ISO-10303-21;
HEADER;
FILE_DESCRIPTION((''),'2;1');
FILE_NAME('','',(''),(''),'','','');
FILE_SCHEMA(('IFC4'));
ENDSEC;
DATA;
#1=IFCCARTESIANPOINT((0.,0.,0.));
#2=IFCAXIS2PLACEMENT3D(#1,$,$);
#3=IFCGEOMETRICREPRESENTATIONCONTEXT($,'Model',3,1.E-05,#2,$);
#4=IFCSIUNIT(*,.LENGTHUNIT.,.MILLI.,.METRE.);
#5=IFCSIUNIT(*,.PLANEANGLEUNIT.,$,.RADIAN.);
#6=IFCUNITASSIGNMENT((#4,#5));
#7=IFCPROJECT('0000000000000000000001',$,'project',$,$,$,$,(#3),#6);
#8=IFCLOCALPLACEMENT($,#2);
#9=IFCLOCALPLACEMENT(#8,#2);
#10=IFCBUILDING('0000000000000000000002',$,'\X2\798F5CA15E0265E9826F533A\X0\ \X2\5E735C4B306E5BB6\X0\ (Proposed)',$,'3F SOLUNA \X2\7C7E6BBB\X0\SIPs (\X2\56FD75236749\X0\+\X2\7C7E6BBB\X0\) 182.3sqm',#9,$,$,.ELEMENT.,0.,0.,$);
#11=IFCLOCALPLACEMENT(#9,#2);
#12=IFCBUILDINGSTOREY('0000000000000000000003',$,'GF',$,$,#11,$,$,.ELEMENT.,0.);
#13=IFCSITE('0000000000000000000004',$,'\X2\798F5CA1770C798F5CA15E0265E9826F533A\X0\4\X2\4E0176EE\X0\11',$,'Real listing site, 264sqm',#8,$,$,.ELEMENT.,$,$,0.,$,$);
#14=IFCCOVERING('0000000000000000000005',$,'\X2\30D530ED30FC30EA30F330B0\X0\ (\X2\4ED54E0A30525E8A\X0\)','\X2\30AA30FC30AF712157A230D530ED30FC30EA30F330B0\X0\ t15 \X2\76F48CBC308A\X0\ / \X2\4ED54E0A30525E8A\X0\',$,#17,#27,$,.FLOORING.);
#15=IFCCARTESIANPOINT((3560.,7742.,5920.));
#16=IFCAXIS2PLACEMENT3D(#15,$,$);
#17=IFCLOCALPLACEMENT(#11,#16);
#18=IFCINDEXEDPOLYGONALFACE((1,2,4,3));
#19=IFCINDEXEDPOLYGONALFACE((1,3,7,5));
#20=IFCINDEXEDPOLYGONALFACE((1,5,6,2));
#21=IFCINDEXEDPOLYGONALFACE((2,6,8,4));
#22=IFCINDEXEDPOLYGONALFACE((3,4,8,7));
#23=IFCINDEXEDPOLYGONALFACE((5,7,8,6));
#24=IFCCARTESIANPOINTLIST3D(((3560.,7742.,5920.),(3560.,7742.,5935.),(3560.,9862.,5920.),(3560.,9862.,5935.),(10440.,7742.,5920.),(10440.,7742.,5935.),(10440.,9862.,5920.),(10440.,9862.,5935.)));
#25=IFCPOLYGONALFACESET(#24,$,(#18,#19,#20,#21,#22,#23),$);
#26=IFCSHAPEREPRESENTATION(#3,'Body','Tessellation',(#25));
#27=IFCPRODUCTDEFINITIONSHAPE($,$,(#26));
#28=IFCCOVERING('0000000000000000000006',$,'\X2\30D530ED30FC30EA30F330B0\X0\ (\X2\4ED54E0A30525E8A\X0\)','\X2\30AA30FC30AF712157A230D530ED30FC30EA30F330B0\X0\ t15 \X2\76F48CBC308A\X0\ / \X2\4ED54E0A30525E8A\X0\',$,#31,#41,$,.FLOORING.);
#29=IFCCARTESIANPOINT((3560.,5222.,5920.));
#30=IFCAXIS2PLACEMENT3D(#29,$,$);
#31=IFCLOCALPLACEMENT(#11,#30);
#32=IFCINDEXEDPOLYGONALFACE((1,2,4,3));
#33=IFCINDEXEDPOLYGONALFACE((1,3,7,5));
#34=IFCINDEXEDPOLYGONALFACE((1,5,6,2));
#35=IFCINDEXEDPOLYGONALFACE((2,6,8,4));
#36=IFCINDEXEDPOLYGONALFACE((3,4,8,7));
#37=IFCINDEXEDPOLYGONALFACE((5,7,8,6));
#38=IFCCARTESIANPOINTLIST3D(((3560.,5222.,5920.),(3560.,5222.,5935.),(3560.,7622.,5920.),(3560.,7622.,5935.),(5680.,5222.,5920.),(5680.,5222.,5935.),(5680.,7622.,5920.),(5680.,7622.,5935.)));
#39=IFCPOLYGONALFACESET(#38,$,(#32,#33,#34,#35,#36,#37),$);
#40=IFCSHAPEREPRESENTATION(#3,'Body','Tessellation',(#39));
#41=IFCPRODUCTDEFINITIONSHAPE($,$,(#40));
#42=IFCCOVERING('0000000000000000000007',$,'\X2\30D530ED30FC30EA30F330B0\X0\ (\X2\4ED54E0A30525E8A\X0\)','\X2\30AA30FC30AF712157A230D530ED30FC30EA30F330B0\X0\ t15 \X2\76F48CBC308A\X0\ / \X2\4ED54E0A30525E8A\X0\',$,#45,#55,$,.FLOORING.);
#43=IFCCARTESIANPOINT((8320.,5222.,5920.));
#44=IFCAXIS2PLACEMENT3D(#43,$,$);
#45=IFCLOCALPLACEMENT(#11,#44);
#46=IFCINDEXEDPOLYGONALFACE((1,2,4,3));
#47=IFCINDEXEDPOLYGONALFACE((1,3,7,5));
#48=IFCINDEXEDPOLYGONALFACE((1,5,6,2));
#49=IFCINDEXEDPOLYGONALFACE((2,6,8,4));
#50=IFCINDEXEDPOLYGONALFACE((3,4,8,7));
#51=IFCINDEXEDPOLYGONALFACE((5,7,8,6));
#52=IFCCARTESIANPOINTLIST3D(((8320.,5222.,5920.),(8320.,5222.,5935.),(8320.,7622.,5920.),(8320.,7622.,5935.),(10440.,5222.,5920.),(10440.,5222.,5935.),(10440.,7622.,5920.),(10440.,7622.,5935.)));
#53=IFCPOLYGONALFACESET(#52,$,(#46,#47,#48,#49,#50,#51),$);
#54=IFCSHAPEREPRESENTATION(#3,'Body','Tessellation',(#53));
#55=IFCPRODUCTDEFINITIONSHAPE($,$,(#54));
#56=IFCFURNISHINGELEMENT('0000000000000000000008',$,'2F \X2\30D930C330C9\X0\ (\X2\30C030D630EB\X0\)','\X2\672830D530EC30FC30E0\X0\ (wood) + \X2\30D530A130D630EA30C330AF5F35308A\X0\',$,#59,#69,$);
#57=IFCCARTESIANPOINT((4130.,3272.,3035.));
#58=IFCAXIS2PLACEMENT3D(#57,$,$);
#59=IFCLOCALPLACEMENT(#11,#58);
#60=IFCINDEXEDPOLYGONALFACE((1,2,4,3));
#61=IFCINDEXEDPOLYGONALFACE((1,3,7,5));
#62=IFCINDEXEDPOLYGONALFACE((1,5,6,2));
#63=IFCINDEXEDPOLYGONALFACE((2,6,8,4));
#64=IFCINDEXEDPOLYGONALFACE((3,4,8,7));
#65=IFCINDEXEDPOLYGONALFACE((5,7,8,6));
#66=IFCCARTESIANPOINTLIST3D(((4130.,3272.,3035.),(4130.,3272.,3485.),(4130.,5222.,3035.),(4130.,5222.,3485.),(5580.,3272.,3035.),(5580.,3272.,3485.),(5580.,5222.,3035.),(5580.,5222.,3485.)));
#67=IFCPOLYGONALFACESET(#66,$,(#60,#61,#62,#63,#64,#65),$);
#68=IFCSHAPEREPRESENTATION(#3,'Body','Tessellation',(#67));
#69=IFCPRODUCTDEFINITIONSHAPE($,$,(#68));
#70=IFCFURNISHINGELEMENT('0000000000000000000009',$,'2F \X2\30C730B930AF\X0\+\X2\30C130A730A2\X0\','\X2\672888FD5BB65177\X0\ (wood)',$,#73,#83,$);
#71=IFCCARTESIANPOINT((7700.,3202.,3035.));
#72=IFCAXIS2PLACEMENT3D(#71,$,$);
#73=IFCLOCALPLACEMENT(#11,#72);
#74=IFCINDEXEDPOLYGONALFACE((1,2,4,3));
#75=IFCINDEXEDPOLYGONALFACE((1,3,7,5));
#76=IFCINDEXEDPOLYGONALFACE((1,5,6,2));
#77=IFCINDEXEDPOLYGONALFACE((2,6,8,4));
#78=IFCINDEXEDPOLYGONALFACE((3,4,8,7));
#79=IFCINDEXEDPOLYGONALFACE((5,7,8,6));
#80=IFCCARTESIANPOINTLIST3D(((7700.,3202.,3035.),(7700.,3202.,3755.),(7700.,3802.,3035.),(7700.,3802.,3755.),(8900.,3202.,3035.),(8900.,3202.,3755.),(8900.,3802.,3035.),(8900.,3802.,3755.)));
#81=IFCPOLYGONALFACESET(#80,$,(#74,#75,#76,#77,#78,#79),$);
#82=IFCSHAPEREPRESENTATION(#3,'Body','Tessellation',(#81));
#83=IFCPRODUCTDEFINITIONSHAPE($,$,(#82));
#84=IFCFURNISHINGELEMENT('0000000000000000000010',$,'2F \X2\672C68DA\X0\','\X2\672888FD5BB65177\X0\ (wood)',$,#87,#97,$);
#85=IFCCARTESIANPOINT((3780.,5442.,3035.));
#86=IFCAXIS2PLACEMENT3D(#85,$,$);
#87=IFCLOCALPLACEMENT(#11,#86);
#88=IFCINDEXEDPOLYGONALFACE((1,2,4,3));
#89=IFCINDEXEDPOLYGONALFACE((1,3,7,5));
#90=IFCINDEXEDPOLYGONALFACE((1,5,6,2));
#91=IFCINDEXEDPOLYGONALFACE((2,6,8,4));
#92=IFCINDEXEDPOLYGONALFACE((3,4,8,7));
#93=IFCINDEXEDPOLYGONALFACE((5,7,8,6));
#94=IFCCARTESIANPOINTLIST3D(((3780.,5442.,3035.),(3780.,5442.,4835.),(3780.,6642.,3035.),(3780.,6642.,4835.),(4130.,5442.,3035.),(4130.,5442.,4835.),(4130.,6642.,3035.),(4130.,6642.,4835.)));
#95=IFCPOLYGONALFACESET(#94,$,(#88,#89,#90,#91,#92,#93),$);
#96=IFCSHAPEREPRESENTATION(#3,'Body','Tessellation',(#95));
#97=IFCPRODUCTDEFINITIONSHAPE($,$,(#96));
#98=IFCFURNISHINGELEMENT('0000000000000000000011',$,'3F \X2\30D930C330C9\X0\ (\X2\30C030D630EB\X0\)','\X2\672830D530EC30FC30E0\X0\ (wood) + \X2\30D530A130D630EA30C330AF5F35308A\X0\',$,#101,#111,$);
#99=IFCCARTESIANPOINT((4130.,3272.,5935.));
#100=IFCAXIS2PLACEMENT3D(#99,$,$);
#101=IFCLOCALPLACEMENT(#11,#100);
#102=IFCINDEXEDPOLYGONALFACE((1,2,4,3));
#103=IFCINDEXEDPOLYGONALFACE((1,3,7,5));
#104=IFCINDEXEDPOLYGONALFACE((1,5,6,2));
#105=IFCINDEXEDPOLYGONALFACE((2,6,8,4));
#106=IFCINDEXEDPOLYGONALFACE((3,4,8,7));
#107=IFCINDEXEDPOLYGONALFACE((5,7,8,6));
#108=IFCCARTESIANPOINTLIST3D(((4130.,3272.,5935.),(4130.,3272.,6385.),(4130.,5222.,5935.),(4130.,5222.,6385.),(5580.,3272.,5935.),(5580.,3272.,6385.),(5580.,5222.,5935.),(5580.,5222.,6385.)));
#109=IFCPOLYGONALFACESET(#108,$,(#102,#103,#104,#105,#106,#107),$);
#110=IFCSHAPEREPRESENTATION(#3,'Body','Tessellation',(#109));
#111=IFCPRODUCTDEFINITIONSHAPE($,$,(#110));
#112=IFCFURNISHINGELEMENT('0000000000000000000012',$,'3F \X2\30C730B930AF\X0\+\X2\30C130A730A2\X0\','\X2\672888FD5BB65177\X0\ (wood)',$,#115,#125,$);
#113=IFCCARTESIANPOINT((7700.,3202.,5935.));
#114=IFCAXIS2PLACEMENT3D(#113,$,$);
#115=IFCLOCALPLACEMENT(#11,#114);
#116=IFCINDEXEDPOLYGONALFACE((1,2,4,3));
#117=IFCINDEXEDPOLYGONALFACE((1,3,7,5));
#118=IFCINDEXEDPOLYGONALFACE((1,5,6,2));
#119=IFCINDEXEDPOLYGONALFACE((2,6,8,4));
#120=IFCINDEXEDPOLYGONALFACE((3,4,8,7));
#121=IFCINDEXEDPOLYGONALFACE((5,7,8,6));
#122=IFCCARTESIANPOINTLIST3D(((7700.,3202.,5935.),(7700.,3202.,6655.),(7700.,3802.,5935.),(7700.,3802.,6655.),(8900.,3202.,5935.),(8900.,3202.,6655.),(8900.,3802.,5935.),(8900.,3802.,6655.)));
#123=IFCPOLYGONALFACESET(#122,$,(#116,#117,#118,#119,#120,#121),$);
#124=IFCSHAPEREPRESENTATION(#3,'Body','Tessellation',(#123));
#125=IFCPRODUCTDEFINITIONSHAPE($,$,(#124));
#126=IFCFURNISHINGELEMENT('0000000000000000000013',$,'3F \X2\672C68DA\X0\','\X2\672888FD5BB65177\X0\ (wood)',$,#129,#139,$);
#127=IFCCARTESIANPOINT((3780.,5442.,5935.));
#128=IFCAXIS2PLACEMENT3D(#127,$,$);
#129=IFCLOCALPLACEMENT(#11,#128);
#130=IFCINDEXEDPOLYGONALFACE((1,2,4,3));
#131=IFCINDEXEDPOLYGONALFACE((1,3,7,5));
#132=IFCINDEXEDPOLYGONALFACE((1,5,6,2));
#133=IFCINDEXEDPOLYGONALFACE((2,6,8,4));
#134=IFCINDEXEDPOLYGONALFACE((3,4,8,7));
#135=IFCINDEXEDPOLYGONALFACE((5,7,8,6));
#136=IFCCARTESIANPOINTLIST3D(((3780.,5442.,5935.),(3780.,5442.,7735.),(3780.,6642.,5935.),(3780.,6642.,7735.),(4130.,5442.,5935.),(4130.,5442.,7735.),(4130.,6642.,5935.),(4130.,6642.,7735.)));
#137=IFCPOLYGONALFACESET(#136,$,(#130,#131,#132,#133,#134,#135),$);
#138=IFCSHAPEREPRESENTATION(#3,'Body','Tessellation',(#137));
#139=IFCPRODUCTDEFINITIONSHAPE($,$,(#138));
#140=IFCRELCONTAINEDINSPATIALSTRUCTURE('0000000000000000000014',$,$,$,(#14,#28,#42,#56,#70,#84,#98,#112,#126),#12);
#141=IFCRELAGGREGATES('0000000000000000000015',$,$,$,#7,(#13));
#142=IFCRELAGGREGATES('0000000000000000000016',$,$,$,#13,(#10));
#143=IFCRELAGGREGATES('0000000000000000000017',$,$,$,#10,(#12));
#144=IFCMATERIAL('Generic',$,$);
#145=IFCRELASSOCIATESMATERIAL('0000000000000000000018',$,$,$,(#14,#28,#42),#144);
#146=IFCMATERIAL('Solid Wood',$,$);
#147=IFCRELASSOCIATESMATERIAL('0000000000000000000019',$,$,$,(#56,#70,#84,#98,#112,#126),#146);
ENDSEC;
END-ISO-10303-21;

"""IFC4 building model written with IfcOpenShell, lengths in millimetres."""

from ifc_helpers import new_model, si_unit, frame, frame_2d, origin, place, context, project, spatial, rectangle, extrude, material, element, save


model = new_model("IFC4")

# Units and contexts
model_context = context("Model", 3, precision=1e-05, world=origin())
ifc_project = project(units=[si_unit("LENGTHUNIT", "METRE", prefix="MILLI"), si_unit("PLANEANGLEUNIT", "RADIAN")], contexts=[model_context])

# Site, building, storey
site_placement = place(None, origin())
site = spatial("IfcSite", under=ifc_project, at=site_placement, Name="福岡県福岡市早良区4丁目11", ObjectType="Real listing site, 264sqm", CompositionType="ELEMENT", RefElevation=0.0)
building_placement = place(site_placement, origin())
building = spatial("IfcBuilding", under=site, at=building_placement, Name="福岡市早良区 平屋の家 (Proposed)", ObjectType="3F SOLUNA 籾殻SIPs (国産杉+籾殻) 182.3sqm", CompositionType="ELEMENT", ElevationOfRefHeight=0.0, ElevationOfTerrain=0.0)
storey_placement = place(building_placement, origin())
storey = spatial("IfcBuildingStorey", under=building, at=storey_placement, Name="GF", CompositionType="ELEMENT", Elevation=0.0)

# Shared definitions
ifc_material_1 = material(Name="Solid Wood")

# Shared definitions
ifc_material_2 = material(Name="Generic")

# Coverings
covering_1_placement = place(storey_placement, frame((3560.0, 7742.0, 5920.0)))
element("IfcCovering", 1, at=covering_1_placement, inside=storey, material=ifc_material_2, Name="フローリング (仕上げ床)", Description="オーク無垢フローリング t15 直貼り / 仕上げ床", PredefinedType="FLOORING", context=model_context, shape_type="SweptSolid", body=[
    extrude(rectangle(XDim=6880.0, YDim=2120.0, at=frame_2d((3440.0, 1060.0))), frame((3560.0, 7742.0, 5920.0)), (0.0, 0.0, 1.0), 15.0),
])
covering_2_placement = place(storey_placement, frame((3560.0, 5222.0, 5920.0)))
element("IfcCovering", 2, at=covering_2_placement, inside=storey, material=ifc_material_2, Name="フローリング (仕上げ床)", Description="オーク無垢フローリング t15 直貼り / 仕上げ床", PredefinedType="FLOORING", context=model_context, shape_type="SweptSolid", body=[
    extrude(rectangle(XDim=2120.0, YDim=2400.0, at=frame_2d((1060.0, 1200.0))), frame((3560.0, 5222.0, 5920.0)), (0.0, 0.0, 1.0), 15.0),
])
covering_3_placement = place(storey_placement, frame((8320.0, 5222.0, 5920.0)))
element("IfcCovering", 3, at=covering_3_placement, inside=storey, material=ifc_material_2, Name="フローリング (仕上げ床)", Description="オーク無垢フローリング t15 直貼り / 仕上げ床", PredefinedType="FLOORING", context=model_context, shape_type="SweptSolid", body=[
    extrude(rectangle(XDim=2120.0, YDim=2400.0, at=frame_2d((1060.0, 1200.0))), frame((8320.0, 5222.0, 5920.0)), (0.0, 0.0, 1.0), 15.0),
])

# Furnishing elements
furnishing_1_placement = place(storey_placement, frame((4130.0, 3272.0, 3035.0)))
element("IfcFurnishingElement", 4, at=furnishing_1_placement, inside=storey, material=ifc_material_1, Name="2F ベッド (ダブル)", Description="木フレーム (wood) + ファブリック張り", context=model_context, shape_type="SweptSolid", body=[
    extrude(rectangle(XDim=1450.0, YDim=1950.0, at=frame_2d((725.0, 975.0))), frame((4130.0, 3272.0, 3035.0)), (0.0, 0.0, 1.0), 450.0),
])
furnishing_2_placement = place(storey_placement, frame((7700.0, 3202.0, 3035.0)))
element("IfcFurnishingElement", 5, at=furnishing_2_placement, inside=storey, material=ifc_material_1, Name="2F デスク+チェア", Description="木製家具 (wood)", context=model_context, shape_type="SweptSolid", body=[
    extrude(rectangle(XDim=1200.0, YDim=600.0, at=frame_2d((600.0, 300.0))), frame((7700.0, 3202.0, 3035.0)), (0.0, 0.0, 1.0), 720.0),
])
furnishing_3_placement = place(storey_placement, frame((3780.0, 5442.0, 3035.0)))
element("IfcFurnishingElement", 6, at=furnishing_3_placement, inside=storey, material=ifc_material_1, Name="2F 本棚", Description="木製家具 (wood)", context=model_context, shape_type="SweptSolid", body=[
    extrude(rectangle(XDim=350.0, YDim=1200.0, at=frame_2d((175.0, 600.0))), frame((3780.0, 5442.0, 3035.0)), (0.0, 0.0, 1.0), 1800.0),
])
furnishing_4_placement = place(storey_placement, frame((4130.0, 3272.0, 5935.0)))
element("IfcFurnishingElement", 7, at=furnishing_4_placement, inside=storey, material=ifc_material_1, Name="3F ベッド (ダブル)", Description="木フレーム (wood) + ファブリック張り", context=model_context, shape_type="SweptSolid", body=[
    extrude(rectangle(XDim=1450.0, YDim=1950.0, at=frame_2d((725.0, 975.0))), frame((4130.0, 3272.0, 5935.0)), (0.0, 0.0, 1.0), 450.0),
])
furnishing_5_placement = place(storey_placement, frame((7700.0, 3202.0, 5935.0)))
element("IfcFurnishingElement", 8, at=furnishing_5_placement, inside=storey, material=ifc_material_1, Name="3F デスク+チェア", Description="木製家具 (wood)", context=model_context, shape_type="SweptSolid", body=[
    extrude(rectangle(XDim=1200.0, YDim=600.0, at=frame_2d((600.0, 300.0))), frame((7700.0, 3202.0, 5935.0)), (0.0, 0.0, 1.0), 720.0),
])
furnishing_6_placement = place(storey_placement, frame((3780.0, 5442.0, 5935.0)))
element("IfcFurnishingElement", 9, at=furnishing_6_placement, inside=storey, material=ifc_material_1, Name="3F 本棚", Description="木製家具 (wood)", context=model_context, shape_type="SweptSolid", body=[
    extrude(rectangle(XDim=350.0, YDim=1200.0, at=frame_2d((175.0, 600.0))), frame((3780.0, 5442.0, 5935.0)), (0.0, 0.0, 1.0), 1800.0),
])

save(model, "model.ifc")
